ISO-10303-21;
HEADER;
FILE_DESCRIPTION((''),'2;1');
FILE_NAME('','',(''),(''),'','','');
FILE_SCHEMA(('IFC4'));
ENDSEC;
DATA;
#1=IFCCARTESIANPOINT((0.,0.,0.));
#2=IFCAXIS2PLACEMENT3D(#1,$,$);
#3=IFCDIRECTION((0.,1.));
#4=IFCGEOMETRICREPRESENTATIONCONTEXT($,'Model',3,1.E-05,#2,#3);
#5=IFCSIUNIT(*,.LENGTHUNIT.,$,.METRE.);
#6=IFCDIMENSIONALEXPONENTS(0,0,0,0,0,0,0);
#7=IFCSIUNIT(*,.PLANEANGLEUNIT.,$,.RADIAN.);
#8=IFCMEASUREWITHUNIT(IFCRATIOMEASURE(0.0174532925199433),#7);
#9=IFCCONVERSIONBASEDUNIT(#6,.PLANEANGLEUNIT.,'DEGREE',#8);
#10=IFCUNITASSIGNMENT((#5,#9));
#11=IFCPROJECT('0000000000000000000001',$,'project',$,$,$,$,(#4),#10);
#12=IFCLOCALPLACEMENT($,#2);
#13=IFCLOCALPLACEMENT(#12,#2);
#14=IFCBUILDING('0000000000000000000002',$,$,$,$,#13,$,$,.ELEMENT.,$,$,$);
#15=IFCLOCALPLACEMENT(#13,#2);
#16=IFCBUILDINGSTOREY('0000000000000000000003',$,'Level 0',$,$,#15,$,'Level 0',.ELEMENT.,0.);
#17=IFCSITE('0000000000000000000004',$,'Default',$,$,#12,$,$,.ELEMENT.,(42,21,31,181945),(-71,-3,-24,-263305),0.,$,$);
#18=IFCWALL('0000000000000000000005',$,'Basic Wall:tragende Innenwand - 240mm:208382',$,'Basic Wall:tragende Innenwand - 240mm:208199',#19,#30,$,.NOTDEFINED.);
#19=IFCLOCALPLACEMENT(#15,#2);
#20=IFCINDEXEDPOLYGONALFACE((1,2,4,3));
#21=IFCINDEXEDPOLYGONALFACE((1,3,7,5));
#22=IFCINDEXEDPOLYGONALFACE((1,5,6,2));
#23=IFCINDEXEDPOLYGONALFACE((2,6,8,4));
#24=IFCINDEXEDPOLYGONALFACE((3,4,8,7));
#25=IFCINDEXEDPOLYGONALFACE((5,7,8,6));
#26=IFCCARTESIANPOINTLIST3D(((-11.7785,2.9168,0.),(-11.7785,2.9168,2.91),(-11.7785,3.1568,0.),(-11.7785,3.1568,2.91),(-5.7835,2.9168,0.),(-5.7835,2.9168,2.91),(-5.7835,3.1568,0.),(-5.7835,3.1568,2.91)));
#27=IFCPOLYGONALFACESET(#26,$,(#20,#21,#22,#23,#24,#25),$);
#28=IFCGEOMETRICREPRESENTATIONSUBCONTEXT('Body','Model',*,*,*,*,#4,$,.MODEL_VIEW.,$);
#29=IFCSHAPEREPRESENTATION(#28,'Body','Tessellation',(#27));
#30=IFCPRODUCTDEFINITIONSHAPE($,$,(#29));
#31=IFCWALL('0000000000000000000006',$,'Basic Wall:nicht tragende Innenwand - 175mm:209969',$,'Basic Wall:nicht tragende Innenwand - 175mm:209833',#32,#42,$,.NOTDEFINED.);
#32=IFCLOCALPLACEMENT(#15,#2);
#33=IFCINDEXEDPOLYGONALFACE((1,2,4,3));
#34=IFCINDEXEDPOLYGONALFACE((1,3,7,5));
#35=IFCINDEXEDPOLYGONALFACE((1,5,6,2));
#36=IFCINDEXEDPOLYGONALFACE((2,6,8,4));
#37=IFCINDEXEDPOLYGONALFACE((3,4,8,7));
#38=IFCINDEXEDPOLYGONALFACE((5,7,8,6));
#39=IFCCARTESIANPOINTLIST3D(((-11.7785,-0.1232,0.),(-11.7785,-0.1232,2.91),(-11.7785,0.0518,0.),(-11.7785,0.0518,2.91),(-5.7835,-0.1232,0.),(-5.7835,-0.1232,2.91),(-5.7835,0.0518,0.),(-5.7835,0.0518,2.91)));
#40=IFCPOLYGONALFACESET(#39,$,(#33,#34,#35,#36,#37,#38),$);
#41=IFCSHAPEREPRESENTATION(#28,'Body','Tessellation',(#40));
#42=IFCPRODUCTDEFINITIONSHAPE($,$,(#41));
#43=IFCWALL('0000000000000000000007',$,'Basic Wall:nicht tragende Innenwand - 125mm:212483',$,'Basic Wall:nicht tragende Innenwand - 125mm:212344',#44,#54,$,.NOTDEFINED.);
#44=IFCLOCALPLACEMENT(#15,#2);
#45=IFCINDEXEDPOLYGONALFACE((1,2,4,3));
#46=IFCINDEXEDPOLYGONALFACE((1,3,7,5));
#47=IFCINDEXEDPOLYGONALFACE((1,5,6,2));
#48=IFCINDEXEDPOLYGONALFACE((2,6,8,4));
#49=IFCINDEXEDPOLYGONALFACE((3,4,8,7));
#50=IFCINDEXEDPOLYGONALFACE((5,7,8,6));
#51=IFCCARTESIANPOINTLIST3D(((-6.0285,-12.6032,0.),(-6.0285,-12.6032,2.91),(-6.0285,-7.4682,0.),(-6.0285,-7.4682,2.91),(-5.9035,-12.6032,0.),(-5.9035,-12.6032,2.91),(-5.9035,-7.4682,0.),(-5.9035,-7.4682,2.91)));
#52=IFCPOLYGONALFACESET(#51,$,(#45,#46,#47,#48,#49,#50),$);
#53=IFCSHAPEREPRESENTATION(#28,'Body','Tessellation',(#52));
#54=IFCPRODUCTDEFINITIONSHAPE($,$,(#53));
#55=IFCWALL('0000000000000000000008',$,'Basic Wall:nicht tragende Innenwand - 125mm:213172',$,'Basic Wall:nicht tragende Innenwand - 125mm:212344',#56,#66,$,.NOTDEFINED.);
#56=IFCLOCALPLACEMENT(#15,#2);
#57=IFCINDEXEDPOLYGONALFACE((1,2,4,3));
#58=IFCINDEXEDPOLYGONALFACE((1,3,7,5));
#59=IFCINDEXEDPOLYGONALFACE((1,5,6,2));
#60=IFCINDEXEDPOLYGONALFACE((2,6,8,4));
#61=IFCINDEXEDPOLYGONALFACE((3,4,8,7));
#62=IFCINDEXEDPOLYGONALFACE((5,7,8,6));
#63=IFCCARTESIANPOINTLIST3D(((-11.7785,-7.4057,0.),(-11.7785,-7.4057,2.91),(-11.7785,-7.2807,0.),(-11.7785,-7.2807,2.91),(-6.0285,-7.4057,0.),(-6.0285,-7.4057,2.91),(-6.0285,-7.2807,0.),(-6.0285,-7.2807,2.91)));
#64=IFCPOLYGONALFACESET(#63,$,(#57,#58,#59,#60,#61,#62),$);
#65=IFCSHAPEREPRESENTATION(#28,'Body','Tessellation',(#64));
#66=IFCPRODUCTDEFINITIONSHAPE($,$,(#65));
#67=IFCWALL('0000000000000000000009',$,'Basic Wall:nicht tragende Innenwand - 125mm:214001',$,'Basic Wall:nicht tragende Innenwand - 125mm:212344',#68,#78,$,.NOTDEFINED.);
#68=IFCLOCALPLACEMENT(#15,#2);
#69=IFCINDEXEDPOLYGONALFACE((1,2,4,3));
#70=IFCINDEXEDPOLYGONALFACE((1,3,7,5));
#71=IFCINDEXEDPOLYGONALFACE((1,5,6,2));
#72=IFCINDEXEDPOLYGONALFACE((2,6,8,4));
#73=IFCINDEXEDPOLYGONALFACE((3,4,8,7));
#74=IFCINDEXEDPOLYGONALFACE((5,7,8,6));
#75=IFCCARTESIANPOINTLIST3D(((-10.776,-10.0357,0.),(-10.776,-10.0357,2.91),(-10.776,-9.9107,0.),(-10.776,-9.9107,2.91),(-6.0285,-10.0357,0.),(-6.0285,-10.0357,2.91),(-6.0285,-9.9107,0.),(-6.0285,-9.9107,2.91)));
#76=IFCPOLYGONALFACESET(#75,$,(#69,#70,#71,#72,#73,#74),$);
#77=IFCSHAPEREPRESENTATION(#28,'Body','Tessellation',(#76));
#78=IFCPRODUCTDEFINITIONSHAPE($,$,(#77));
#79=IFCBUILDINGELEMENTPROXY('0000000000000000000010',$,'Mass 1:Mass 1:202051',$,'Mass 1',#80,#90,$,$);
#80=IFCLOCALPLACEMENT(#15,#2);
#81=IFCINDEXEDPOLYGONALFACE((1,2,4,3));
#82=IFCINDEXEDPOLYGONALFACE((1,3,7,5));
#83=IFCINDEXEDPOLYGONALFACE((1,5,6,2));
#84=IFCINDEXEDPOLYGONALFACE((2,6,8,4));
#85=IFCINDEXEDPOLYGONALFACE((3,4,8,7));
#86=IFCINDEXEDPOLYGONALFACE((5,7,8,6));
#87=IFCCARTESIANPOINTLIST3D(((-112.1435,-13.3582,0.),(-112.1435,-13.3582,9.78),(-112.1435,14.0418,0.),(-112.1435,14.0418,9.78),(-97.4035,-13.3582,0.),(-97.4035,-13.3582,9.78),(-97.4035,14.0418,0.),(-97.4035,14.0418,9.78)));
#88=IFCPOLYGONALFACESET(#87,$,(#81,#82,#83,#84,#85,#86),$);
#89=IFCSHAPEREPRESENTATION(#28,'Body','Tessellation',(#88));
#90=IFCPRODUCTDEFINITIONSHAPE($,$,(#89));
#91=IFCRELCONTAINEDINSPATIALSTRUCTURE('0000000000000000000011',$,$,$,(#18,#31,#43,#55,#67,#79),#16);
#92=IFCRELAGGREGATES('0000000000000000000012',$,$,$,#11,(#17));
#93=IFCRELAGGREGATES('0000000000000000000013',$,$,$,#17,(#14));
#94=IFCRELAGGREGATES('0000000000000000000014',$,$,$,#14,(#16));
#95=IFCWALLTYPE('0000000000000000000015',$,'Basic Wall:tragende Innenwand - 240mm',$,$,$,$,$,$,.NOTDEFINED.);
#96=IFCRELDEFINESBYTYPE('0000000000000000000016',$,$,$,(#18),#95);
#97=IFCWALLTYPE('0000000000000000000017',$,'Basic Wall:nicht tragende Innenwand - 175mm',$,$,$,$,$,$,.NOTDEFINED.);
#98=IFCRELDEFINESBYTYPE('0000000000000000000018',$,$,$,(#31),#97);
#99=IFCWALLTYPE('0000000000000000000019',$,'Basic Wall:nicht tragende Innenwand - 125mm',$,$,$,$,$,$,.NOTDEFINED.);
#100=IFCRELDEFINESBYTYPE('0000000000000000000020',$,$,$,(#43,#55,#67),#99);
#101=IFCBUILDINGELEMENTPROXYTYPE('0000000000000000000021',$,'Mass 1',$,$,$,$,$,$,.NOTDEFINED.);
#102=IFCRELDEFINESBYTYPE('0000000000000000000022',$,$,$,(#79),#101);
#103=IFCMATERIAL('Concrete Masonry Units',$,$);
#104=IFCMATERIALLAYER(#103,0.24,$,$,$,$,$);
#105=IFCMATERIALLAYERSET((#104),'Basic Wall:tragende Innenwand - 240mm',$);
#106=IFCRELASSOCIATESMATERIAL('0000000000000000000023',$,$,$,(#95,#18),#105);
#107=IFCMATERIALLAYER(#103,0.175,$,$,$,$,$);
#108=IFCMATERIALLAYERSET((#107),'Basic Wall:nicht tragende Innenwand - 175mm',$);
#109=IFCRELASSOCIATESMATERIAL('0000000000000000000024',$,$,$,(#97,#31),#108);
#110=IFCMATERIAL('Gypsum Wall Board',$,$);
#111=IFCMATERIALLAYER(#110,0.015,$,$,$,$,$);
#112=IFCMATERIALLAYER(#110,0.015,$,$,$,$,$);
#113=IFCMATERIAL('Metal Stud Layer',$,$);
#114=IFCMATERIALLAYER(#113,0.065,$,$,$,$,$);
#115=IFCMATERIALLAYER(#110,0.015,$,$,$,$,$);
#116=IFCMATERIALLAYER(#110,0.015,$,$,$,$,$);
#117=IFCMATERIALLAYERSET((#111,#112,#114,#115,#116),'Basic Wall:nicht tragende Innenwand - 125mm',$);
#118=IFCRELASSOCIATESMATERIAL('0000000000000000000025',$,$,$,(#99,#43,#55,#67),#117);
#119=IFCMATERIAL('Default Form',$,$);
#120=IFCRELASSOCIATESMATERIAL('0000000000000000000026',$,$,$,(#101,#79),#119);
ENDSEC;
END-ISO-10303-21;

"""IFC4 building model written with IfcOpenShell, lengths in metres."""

from ifc_helpers import new_model, entity, si_unit, converted_unit, direction, frame, frame_2d, origin, origin_2d_with_axis, place, context, subcontext, project, spatial, polyline, rectangle, extrude, clip, bounded_halfspace, source, transform, mapped, material, layer, layer_set, layer_usage, type_object, type_shapes, element, save


model = new_model("IFC4")

# Units and contexts
model_context = context("Model", 3, precision=1e-05, world=origin(), true_north=direction((0.0, 1.0)))
body_context = subcontext(model_context, "Body", "Model", "MODEL_VIEW")
ifc_project = project(units=[si_unit("LENGTHUNIT", "METRE"), converted_unit("PLANEANGLEUNIT", "DEGREE", entity("IfcRatioMeasure", 0.0174532925199433), si_unit("PLANEANGLEUNIT", "RADIAN"), dimensions=[0, 0, 0, 0, 0, 0, 0])], contexts=[model_context])

# Site, building, storey
site_placement = place(None, origin())
site = spatial("IfcSite", under=ifc_project, at=site_placement, Name="Default", CompositionType="ELEMENT", RefLatitude=(42, 21, 31, 181945), RefLongitude=(-71, -3, -24, -263305), RefElevation=0.0)
building_placement = place(site_placement, origin())
building = spatial("IfcBuilding", under=site, at=building_placement, CompositionType="ELEMENT")
storey_placement = place(building_placement, origin())
storey = spatial("IfcBuildingStorey", under=building, at=storey_placement, Name="Level 0", LongName="Level 0", CompositionType="ELEMENT", Elevation=0.0)

# Walls
ifc_material_1 = material(Name="Concrete Masonry Units")
ifc_layer_1 = layer(ifc_material_1, 0.24)
ifc_layer_set_1 = layer_set([ifc_layer_1], Name="Basic Wall:tragende Innenwand - 240mm")
ifc_layer_usage_1 = layer_usage(ifc_layer_set_1, "AXIS2", "NEGATIVE", 0.12)
wall_type_1 = type_object("IfcWallType", Name="Basic Wall:tragende Innenwand - 240mm", PredefinedType="NOTDEFINED", material=ifc_layer_set_1)
wall_1_placement = place(storey_placement, frame((-11.7785, 3.0368, 0.0)))
element("IfcWall", 1, at=wall_1_placement, inside=storey, type_object=wall_type_1, material=ifc_layer_usage_1, Name="Basic Wall:tragende Innenwand - 240mm:208382", ObjectType="Basic Wall:tragende Innenwand - 240mm:208199", PredefinedType="NOTDEFINED", context=body_context, shape_type="Clipping", body=[
    clip(extrude(rectangle(XDim=5.995, YDim=0.24, at=frame_2d((2.9975, 0.0), x_axis=(-1.0, 0.0))), origin(), (0.0, 0.0, 1.0), 2.91), bounded_halfspace(frame((0.0, -0.12, 2.91), z_axis=(0.0, 0.0, -1.0), x_axis=(0.0, -1.0, 0.0)), True, frame((0.0, -0.12, 2.91)), polyline([(0.0, 0.0), (2.055, 0.0), (5.755, 0.0), (5.995, 0.0), (5.995, 0.24), (5.875, 0.24), (5.75, 0.24), (0.0, 0.24), (0.0, 0.0)]))),
])
ifc_layer_2 = layer(ifc_material_1, 0.175)
ifc_layer_set_2 = layer_set([ifc_layer_2], Name="Basic Wall:nicht tragende Innenwand - 175mm")
ifc_layer_usage_2 = layer_usage(ifc_layer_set_2, "AXIS2", "NEGATIVE", 0.0875)
wall_type_2 = type_object("IfcWallType", Name="Basic Wall:nicht tragende Innenwand - 175mm", PredefinedType="NOTDEFINED", material=ifc_layer_set_2)
wall_2_placement = place(storey_placement, frame((-11.7785, -0.0357, 0.0)))
element("IfcWall", 2, at=wall_2_placement, inside=storey, type_object=wall_type_2, material=ifc_layer_usage_2, Name="Basic Wall:nicht tragende Innenwand - 175mm:209969", ObjectType="Basic Wall:nicht tragende Innenwand - 175mm:209833", PredefinedType="NOTDEFINED", context=body_context, shape_type="Clipping", body=[
    clip(extrude(rectangle(XDim=5.995, YDim=0.175, at=frame_2d((2.9975, 0.0), x_axis=(-1.0, 0.0))), origin(), (0.0, 0.0, 1.0), 2.91), bounded_halfspace(frame((0.0, -0.0875, 2.91), z_axis=(0.0, 0.0, -1.0), x_axis=(0.0, -1.0, 0.0)), True, frame((0.0, -0.0875, 2.91)), polyline([(0.0, 0.0), (5.995, 0.0), (5.995, 0.175), (5.755, 0.175), (2.055, 0.175), (0.0, 0.175), (0.0, 0.0)]))),
])
ifc_material_2 = material(Name="Gypsum Wall Board")
ifc_layer_3 = layer(ifc_material_2, 0.015)
ifc_layer_4 = layer(ifc_material_2, 0.015)
ifc_material_3 = material(Name="Metal Stud Layer")
ifc_layer_5 = layer(ifc_material_3, 0.065)
ifc_layer_6 = layer(ifc_material_2, 0.015)
ifc_layer_7 = layer(ifc_material_2, 0.015)
ifc_layer_set_3 = layer_set([ifc_layer_3, ifc_layer_4, ifc_layer_5, ifc_layer_6, ifc_layer_7], Name="Basic Wall:nicht tragende Innenwand - 125mm")
ifc_layer_usage_3 = layer_usage(ifc_layer_set_3, "AXIS2", "NEGATIVE", 0.0625)
wall_type_3 = type_object("IfcWallType", Name="Basic Wall:nicht tragende Innenwand - 125mm", PredefinedType="NOTDEFINED", material=ifc_layer_set_3)
wall_3_placement = place(storey_placement, frame((-5.966, -7.4682, 0.0), z_axis=(0.0, 0.0, 1.0), x_axis=(0.0, -1.0, 0.0)))
element("IfcWall", 3, at=wall_3_placement, inside=storey, type_object=wall_type_3, material=ifc_layer_usage_3, Name="Basic Wall:nicht tragende Innenwand - 125mm:212483", ObjectType="Basic Wall:nicht tragende Innenwand - 125mm:212344", PredefinedType="NOTDEFINED", context=body_context, shape_type="Clipping", body=[
    clip(extrude(rectangle(XDim=5.135, YDim=0.125, at=frame_2d((2.5675, 0.0), x_axis=(-1.0, 0.0))), origin(), (0.0, 0.0, 1.0), 2.91), bounded_halfspace(frame((0.0, -0.0625, 2.91), z_axis=(0.0, 0.0, -1.0), x_axis=(1.0, 0.0, 0.0)), True, frame((0.0, -0.0625, 2.91)), polyline([(0.0, 0.0), (2.4425, 0.0), (2.5675, 0.0), (5.135, 0.0), (5.135, 0.125), (0.0, 0.125), (0.0, 0.0)]))),
])
ifc_layer_usage_4 = layer_usage(ifc_layer_set_3, "AXIS2", "NEGATIVE", 0.0625)
wall_4_placement = place(storey_placement, frame((-11.7785, -7.3432, 0.0)))
element("IfcWall", 4, at=wall_4_placement, inside=storey, type_object=wall_type_3, material=ifc_layer_usage_4, Name="Basic Wall:nicht tragende Innenwand - 125mm:213172", ObjectType="Basic Wall:nicht tragende Innenwand - 125mm:212344", PredefinedType="NOTDEFINED", context=body_context, shape_type="Clipping", body=[
    clip(extrude(rectangle(XDim=5.75, YDim=0.125, at=frame_2d((2.875, 0.0), x_axis=(-1.0, 0.0))), origin(), (0.0, 0.0, 1.0), 2.91), bounded_halfspace(frame((0.0, -0.0625, 2.91), z_axis=(0.0, 0.0, -1.0), x_axis=(0.0, -1.0, 0.0)), True, frame((0.0, -0.0625, 2.91)), polyline([(0.0, 0.0), (5.75, 0.0), (5.75, 0.125), (0.0, 0.125), (0.0, 0.0)]))),
])
ifc_layer_usage_5 = layer_usage(ifc_layer_set_3, "AXIS2", "NEGATIVE", 0.0625)
wall_5_placement = place(storey_placement, frame((-10.776, -9.9732, 0.0)))
element("IfcWall", 5, at=wall_5_placement, inside=storey, type_object=wall_type_3, material=ifc_layer_usage_5, Name="Basic Wall:nicht tragende Innenwand - 125mm:214001", ObjectType="Basic Wall:nicht tragende Innenwand - 125mm:212344", PredefinedType="NOTDEFINED", context=body_context, shape_type="Clipping", body=[
    clip(extrude(rectangle(XDim=4.7475, YDim=0.125, at=frame_2d((2.3737, 0.0), x_axis=(-1.0, 0.0))), origin(), (0.0, 0.0, 1.0), 2.91), bounded_halfspace(frame((0.0, -0.0625, 2.91), z_axis=(0.0, 0.0, -1.0), x_axis=(0.0, -1.0, 0.0)), True, frame((0.0, -0.0625, 2.91)), polyline([(0.0, 0.0), (4.7475, 0.0), (4.7475, 0.125), (0.0, 0.125), (0.0, 0.0)]))),
])

# Building element proxy
ifc_material_4 = material(Name="Default Form")
building_element_proxy_type = type_object("IfcBuildingElementProxyType", Name="Mass 1", material=ifc_material_4)
shared_shape_1 = source(origin(), body_context, "Body", "SweptSolid", [
    extrude(rectangle(XDim=14.74, YDim=27.4, at=origin_2d_with_axis()), frame((7.37, 13.7, 0.0), z_axis=(0.0, 0.0, 1.0), x_axis=(-1.0, 0.0, 0.0)), (0.0, 0.0, 1.0), 9.78),
])
type_shapes(building_element_proxy_type, [shared_shape_1])
proxy_placement = place(storey_placement, frame((-112.1435, -13.3582, 0.0)))
element("IfcBuildingElementProxy", 6, at=proxy_placement, inside=storey, type_object=building_element_proxy_type, material=ifc_material_4, Name="Mass 1:Mass 1:202051", ObjectType="Mass 1", context=body_context, shape_type="MappedRepresentation", body=[
    mapped(shared_shape_1, transform((0.0, 0.0, 0.0), scale=1.0)),
])

save(model, "model.ifc")
